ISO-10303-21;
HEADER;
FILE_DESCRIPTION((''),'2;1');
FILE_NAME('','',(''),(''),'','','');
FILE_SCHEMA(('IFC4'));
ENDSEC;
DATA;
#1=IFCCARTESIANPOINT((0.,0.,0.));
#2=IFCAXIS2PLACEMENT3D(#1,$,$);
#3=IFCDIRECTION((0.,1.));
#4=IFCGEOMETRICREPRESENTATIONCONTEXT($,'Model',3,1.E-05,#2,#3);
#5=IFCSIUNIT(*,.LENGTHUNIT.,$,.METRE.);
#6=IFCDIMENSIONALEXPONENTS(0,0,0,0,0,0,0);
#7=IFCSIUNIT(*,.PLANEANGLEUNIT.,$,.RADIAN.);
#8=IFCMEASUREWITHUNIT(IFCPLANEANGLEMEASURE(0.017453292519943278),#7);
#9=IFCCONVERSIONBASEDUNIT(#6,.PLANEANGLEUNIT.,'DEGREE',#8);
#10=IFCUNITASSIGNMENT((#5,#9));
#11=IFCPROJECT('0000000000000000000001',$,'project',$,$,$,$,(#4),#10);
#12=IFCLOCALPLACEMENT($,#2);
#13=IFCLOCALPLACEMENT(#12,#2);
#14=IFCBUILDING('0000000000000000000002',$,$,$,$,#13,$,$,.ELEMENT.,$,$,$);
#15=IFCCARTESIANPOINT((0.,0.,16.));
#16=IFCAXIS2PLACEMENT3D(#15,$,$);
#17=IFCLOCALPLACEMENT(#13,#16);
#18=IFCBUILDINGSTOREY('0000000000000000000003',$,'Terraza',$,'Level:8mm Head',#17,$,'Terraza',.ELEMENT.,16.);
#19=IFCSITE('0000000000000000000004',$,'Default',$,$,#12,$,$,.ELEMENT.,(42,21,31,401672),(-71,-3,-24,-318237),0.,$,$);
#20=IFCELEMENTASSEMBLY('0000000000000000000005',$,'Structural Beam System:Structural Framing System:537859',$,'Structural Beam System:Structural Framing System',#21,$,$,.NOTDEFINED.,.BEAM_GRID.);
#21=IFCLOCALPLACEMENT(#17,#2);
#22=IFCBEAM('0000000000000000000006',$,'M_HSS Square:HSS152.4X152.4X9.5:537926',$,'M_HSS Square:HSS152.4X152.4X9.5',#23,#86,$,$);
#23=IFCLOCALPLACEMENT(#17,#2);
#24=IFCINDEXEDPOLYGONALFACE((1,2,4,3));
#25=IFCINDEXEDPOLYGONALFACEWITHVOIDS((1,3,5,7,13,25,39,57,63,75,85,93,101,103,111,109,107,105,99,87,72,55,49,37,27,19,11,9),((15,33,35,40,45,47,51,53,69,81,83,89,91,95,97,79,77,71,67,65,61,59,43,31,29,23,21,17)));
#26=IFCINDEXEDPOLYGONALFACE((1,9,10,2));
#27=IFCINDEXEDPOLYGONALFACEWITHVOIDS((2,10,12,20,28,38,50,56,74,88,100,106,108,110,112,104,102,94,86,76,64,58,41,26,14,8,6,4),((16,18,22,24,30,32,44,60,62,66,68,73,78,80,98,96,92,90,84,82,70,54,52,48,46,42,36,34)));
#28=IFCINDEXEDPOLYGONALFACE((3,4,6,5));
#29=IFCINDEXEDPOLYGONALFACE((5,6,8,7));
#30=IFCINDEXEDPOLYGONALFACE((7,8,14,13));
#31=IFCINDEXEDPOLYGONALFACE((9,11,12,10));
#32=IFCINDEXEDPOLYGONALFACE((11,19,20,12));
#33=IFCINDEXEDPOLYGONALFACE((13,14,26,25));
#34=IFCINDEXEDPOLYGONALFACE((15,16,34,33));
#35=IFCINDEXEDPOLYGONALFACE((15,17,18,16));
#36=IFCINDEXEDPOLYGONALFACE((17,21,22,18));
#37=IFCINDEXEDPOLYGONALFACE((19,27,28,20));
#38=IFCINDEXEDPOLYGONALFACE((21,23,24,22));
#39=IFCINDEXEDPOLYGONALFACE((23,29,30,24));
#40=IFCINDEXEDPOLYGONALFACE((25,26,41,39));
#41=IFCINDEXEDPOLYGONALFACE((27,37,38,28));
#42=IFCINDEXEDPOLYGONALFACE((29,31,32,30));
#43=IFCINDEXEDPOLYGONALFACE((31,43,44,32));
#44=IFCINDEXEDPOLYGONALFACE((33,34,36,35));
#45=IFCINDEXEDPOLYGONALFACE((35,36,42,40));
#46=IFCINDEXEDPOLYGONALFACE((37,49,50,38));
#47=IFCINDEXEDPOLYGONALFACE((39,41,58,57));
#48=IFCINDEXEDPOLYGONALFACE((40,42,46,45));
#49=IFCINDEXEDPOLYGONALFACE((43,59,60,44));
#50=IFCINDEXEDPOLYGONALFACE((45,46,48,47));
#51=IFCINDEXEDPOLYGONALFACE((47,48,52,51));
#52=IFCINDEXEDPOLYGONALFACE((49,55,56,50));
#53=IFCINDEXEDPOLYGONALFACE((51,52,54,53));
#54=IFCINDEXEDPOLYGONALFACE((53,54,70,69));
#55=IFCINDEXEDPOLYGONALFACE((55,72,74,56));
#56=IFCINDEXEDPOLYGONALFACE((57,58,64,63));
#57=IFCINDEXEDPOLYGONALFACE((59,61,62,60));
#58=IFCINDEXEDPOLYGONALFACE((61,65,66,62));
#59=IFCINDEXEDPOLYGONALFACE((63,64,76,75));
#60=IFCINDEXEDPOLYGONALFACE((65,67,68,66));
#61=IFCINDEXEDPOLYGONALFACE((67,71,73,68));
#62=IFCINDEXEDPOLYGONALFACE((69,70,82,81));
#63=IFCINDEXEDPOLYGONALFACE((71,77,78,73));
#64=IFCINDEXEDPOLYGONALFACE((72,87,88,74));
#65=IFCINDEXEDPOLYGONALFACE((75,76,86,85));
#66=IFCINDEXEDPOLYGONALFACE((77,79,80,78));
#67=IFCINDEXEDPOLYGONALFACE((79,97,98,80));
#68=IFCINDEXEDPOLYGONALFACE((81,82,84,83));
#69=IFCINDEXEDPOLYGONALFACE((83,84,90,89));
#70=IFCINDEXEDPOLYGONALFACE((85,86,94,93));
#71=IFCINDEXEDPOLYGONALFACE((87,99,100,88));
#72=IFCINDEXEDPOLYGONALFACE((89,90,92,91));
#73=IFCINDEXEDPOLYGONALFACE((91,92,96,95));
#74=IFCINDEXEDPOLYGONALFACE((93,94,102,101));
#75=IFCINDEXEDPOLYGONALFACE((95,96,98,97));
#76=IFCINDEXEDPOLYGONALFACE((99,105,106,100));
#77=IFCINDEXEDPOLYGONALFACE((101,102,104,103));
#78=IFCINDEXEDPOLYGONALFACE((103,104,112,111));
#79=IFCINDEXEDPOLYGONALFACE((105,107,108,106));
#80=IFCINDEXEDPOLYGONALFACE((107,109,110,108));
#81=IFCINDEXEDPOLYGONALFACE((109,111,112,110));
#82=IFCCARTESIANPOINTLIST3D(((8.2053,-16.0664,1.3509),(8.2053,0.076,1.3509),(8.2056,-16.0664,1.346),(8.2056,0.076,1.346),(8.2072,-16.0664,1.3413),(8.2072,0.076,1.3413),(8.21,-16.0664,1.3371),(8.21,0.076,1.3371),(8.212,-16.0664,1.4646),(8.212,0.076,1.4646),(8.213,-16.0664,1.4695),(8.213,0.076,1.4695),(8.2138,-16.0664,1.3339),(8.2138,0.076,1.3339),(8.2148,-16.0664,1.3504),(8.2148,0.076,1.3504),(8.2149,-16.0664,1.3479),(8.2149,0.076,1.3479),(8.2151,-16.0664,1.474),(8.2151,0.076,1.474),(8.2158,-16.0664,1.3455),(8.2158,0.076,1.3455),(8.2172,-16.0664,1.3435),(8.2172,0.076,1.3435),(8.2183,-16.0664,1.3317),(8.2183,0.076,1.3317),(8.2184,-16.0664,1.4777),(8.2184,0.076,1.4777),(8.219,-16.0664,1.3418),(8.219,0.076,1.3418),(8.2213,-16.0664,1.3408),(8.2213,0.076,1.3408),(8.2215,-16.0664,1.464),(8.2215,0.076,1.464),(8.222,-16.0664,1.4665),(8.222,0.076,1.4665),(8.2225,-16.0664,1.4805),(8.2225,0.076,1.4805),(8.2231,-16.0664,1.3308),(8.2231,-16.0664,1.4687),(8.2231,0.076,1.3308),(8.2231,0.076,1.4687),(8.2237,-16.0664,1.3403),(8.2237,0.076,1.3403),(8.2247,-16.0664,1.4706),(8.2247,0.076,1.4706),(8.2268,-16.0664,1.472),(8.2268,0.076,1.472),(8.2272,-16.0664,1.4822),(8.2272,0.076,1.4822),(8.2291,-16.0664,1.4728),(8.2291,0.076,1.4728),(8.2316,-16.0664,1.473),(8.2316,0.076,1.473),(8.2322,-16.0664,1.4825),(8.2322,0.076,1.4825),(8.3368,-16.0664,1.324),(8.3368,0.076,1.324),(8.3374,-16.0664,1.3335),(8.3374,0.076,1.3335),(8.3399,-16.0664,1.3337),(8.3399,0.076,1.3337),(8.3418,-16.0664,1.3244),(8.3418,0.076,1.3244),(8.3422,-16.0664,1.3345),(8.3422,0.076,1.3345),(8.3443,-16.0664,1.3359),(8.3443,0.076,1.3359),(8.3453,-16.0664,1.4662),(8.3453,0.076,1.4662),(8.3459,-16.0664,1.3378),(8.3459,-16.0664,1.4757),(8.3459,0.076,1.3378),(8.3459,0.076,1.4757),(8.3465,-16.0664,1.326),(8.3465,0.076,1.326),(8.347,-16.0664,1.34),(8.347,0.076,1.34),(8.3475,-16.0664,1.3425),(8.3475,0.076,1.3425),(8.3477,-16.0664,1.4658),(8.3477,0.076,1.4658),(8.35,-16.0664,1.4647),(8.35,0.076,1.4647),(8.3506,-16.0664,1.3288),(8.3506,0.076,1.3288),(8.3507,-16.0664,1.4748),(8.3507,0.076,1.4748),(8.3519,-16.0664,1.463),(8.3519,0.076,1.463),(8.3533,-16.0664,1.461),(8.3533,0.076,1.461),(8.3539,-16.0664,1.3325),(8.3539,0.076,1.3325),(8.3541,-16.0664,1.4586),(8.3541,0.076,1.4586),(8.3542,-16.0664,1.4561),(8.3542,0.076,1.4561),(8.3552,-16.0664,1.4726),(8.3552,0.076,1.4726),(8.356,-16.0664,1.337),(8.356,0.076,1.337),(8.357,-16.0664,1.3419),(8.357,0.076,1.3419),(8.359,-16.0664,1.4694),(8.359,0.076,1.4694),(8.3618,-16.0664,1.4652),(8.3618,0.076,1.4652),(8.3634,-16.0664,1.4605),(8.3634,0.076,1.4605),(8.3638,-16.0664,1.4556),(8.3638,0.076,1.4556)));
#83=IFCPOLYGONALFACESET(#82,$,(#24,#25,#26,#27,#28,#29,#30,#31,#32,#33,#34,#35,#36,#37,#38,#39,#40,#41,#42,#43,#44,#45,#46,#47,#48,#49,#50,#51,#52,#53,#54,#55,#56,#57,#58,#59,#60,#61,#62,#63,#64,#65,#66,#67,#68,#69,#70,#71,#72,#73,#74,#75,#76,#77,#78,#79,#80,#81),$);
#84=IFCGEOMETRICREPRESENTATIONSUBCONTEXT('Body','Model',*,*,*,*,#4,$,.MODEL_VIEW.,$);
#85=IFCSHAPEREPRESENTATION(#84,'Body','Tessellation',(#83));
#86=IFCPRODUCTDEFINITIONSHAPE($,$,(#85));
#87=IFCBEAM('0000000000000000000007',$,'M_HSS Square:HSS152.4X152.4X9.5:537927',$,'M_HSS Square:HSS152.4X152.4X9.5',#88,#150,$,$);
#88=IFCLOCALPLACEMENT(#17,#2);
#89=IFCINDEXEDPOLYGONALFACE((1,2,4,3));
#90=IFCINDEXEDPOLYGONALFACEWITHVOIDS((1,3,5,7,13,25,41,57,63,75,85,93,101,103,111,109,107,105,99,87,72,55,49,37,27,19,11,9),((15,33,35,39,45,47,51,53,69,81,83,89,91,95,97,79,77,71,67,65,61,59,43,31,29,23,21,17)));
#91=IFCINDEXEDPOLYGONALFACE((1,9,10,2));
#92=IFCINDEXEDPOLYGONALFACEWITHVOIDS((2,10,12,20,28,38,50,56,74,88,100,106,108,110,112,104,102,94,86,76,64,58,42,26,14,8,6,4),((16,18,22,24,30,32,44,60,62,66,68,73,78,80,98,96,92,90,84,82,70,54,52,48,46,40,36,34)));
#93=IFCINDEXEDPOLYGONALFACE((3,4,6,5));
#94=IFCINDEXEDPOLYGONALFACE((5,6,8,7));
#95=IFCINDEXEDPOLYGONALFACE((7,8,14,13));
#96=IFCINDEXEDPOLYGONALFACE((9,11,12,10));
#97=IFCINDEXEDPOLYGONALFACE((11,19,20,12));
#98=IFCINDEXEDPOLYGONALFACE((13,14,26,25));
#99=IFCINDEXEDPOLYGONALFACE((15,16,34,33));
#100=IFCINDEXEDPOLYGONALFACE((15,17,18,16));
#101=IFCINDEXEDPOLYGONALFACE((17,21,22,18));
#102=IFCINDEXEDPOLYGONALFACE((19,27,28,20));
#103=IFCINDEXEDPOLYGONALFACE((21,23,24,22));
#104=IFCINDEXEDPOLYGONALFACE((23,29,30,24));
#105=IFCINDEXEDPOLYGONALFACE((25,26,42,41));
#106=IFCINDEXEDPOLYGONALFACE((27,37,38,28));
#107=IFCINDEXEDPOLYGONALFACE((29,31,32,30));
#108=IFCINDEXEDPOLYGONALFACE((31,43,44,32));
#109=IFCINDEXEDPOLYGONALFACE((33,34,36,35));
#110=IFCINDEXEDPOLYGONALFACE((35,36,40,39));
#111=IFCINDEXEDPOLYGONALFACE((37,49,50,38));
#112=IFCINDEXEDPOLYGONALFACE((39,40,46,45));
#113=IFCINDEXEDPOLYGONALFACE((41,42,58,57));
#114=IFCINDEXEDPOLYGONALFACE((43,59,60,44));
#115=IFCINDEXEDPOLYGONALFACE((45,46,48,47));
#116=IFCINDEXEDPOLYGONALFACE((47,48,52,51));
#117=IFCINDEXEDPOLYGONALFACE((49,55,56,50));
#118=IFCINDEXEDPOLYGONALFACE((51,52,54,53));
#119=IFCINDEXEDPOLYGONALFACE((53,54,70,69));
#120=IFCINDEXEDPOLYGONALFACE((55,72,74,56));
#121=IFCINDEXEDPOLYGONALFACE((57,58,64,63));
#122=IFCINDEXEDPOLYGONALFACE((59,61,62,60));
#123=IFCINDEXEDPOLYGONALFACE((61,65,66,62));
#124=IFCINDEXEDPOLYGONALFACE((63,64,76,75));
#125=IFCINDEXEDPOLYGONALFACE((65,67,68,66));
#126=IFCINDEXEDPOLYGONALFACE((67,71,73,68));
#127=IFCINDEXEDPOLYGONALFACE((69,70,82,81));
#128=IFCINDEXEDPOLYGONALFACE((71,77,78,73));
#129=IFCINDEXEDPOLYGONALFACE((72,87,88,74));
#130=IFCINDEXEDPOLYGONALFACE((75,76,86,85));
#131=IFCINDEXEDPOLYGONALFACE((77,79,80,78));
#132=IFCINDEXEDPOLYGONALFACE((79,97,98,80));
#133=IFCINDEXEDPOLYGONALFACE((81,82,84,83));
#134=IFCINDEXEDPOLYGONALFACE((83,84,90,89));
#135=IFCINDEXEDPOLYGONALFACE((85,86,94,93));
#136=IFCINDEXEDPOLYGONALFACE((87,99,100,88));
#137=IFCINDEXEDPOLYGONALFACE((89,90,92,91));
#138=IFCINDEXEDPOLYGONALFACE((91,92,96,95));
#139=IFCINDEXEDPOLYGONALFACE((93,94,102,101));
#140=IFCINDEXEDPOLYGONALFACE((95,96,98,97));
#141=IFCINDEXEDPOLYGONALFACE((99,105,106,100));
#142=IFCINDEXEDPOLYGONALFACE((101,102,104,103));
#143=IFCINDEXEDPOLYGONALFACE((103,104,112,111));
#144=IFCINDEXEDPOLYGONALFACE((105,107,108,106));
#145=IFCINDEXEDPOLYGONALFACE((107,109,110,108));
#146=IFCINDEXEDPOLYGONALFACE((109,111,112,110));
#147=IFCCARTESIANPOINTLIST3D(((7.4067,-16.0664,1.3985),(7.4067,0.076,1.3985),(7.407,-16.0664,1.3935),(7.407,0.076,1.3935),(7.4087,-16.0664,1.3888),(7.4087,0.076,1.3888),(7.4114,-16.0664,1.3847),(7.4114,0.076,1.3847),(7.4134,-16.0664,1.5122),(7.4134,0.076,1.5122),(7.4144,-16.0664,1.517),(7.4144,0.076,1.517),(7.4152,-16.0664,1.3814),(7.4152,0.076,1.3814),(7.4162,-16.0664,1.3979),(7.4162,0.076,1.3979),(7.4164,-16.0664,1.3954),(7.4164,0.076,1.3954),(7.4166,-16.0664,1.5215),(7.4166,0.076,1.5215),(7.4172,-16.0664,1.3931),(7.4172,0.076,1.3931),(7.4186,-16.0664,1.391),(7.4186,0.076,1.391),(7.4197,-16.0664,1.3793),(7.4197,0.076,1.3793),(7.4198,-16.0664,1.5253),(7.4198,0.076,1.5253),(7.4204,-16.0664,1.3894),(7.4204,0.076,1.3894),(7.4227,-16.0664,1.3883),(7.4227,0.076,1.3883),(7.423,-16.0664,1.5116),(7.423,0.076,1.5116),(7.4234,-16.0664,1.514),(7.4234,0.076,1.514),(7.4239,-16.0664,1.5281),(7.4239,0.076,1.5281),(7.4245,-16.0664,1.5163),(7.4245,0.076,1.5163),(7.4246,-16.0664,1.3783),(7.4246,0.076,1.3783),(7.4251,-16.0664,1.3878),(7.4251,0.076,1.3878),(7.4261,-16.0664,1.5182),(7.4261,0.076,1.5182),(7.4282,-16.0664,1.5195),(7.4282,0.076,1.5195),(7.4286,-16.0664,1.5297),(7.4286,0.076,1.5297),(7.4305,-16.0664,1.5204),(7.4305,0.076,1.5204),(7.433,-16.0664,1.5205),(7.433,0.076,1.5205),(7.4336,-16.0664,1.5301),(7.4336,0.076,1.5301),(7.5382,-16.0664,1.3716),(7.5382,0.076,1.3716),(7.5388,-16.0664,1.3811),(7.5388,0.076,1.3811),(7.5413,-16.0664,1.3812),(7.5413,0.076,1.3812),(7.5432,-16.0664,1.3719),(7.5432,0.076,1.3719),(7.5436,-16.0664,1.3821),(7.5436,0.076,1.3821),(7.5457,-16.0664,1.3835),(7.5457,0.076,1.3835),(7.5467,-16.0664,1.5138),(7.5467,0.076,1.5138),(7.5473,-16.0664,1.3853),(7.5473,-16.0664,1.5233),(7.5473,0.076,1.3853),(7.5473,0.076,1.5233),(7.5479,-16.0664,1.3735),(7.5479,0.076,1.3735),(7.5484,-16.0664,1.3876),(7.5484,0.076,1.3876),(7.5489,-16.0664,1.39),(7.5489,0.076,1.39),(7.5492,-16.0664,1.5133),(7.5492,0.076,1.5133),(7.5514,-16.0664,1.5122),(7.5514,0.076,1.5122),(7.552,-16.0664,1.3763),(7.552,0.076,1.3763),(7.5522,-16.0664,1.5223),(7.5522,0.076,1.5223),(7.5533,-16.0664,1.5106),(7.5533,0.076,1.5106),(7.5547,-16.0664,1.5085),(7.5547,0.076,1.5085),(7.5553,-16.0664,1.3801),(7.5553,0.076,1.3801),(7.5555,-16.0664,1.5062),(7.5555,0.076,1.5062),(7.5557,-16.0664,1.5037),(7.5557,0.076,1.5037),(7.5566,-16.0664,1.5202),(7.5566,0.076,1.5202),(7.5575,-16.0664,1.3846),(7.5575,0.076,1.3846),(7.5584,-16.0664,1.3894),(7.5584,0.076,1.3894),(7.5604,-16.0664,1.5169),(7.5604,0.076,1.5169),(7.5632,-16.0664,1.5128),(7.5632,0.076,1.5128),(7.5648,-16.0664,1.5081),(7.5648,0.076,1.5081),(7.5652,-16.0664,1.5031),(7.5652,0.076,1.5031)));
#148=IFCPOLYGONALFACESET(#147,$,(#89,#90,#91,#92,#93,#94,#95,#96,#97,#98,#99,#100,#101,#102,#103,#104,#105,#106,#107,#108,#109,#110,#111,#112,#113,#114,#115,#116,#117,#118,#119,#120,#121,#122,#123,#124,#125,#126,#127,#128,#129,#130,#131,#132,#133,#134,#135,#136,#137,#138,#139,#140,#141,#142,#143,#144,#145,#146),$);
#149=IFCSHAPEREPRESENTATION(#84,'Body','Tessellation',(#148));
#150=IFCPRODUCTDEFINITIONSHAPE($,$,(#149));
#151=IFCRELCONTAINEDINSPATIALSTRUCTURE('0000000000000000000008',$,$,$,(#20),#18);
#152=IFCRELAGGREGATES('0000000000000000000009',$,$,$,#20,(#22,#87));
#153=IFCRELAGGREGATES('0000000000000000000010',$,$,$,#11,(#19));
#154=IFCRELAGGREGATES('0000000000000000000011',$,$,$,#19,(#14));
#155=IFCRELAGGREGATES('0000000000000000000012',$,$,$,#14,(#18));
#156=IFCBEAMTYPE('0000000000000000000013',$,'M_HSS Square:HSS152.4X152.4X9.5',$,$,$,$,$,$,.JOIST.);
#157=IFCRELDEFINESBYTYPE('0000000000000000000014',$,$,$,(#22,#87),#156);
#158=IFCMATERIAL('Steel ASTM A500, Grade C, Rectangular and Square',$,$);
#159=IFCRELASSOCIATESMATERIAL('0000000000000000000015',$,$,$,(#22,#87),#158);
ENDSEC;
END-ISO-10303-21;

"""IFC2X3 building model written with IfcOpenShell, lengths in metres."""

from ifc_helpers import new_model, entity, si_unit, converted_unit, direction, frame, frame_2d, origin, place, context, subcontext, project, spatial, polyline, circle_curve, parameter, trimmed, segment, composite_curve, outline, extrude, material, type_object, element, aggregate, save


model = new_model("IFC2X3")

# Units and contexts
model_context = context("Model", 3, precision=1e-05, world=origin(), true_north=direction((0.0, 1.0)))
body_context = subcontext(model_context, "Body", "Model", "MODEL_VIEW")
ifc_project = project(units=[si_unit("LENGTHUNIT", "METRE"), converted_unit("PLANEANGLEUNIT", "DEGREE", entity("IfcPlaneAngleMeasure", 0.017453292519943278), si_unit("PLANEANGLEUNIT", "RADIAN"), dimensions=[0, 0, 0, 0, 0, 0, 0])], contexts=[model_context])

# Site, building, storey
site_placement = place(None, origin())
site = spatial("IfcSite", under=ifc_project, at=site_placement, Name="Default", CompositionType="ELEMENT", RefLatitude=(42, 21, 31, 401672), RefLongitude=(-71, -3, -24, -318237), RefElevation=0.0)
building_placement = place(site_placement, origin())
building = spatial("IfcBuilding", under=site, at=building_placement, CompositionType="ELEMENT")
storey_placement = place(building_placement, frame((0.0, 0.0, 16.0)))
storey = spatial("IfcBuildingStorey", under=building, at=storey_placement, Name="Terraza", ObjectType="Level:8mm Head", LongName="Terraza", CompositionType="ELEMENT", Elevation=16.0)

# Element assembly, beams
assembly_1_placement = place(storey_placement, origin())
assembly_1 = element("IfcElementAssembly", 1, at=assembly_1_placement, inside=storey, Name="Structural Beam System:Structural Framing System:537859", ObjectType="Structural Beam System:Structural Framing System", AssemblyPlace="NOTDEFINED", PredefinedType="BEAM_GRID")
ifc_material_1 = material(Name="Steel ASTM A500, Grade C, Rectangular and Square")
beam_type = type_object("IfcBeamType", Name="M_HSS Square:HSS152.4X152.4X9.5", PredefinedType="JOIST")
beam_1_placement = place(assembly_1_placement, frame((8.28, 0.076, 1.3274), z_axis=(0.0, 0.0, 1.0), x_axis=(0.0, -1.0, 0.0)))
beam_1 = element("IfcBeam", 2, at=beam_1_placement, type_object=beam_type, material=ifc_material_1, Name="M_HSS Square:HSS152.4X152.4X9.5:537926", ObjectType="M_HSS Square:HSS152.4X152.4X9.5", context=body_context, shape_type="SweptSolid", body=[
    extrude(outline(composite_curve([segment(polyline([(-0.0569, -0.076), (0.0569, -0.076)]), True, "CONTINUOUS"), segment(trimmed(circle_curve(frame_2d((0.0569, -0.0569), x_axis=(0.0, 1.0)), 0.0191), [parameter(180.0)], [parameter(270.0)], True, "PARAMETER"), True, "CONTINUOUS"), segment(polyline([(0.076, -0.0569), (0.076, 0.0569)]), True, "CONTINUOUS"), segment(trimmed(circle_curve(frame_2d((0.0569, 0.0569), x_axis=(0.0, 1.0)), 0.0191), [parameter(270.0)], [parameter(0.0)], True, "PARAMETER"), True, "CONTINUOUS"), segment(polyline([(0.0569, 0.076), (-0.0569, 0.076)]), True, "CONTINUOUS"), segment(trimmed(circle_curve(frame_2d((-0.0569, 0.0569), x_axis=(0.0, 1.0)), 0.0191), [parameter(0.0)], [parameter(90.0)], True, "PARAMETER"), True, "CONTINUOUS"), segment(polyline([(-0.076, 0.0569), (-0.076, -0.0569)]), True, "CONTINUOUS"), segment(trimmed(circle_curve(frame_2d((-0.0569, -0.0569), x_axis=(0.0, 1.0)), 0.0191), [parameter(90.0)], [parameter(180.0)], True, "PARAMETER"), True, "CONTINUOUS")], self_intersect=False), holes=[composite_curve([segment(trimmed(circle_curve(frame_2d((-0.0569, 0.0569), x_axis=(0.0, 1.0)), 0.0095), [parameter(360.0)], [parameter(90.0)], True, "PARAMETER"), False, "CONTINUOUS"), segment(polyline([(-0.0569, 0.0665), (0.0569, 0.0665)]), True, "CONTINUOUS"), segment(trimmed(circle_curve(frame_2d((0.0569, 0.0569), x_axis=(0.0, 1.0)), 0.0095), [parameter(270.0)], [parameter(360.0)], True, "PARAMETER"), False, "CONTINUOUS"), segment(polyline([(0.0665, 0.0569), (0.0665, -0.0569)]), True, "CONTINUOUS"), segment(trimmed(circle_curve(frame_2d((0.0569, -0.0569), x_axis=(0.0, 1.0)), 0.0095), [parameter(180.0)], [parameter(270.0)], True, "PARAMETER"), False, "CONTINUOUS"), segment(polyline([(0.0569, -0.0665), (-0.0569, -0.0665)]), True, "CONTINUOUS"), segment(trimmed(circle_curve(frame_2d((-0.0569, -0.0569), x_axis=(0.0, 1.0)), 0.0095), [parameter(90.0)], [parameter(180.0)], True, "PARAMETER"), False, "CONTINUOUS"), segment(polyline([(-0.0665, -0.0569), (-0.0665, 0.0569)]), True, "CONTINUOUS")], self_intersect=False)]), frame((0.0, 0.0045, 0.0759), z_axis=(1.0, 0.0, 0.0), x_axis=(0.0, -0.059434, -0.998232)), (0.0, 0.0, 1.0), 16.1424),
])
beam_2_placement = place(assembly_1_placement, frame((7.4814, 0.076, 1.3749), z_axis=(0.0, 0.0, 1.0), x_axis=(0.0, -1.0, 0.0)))
beam_2 = element("IfcBeam", 3, at=beam_2_placement, type_object=beam_type, material=ifc_material_1, Name="M_HSS Square:HSS152.4X152.4X9.5:537927", ObjectType="M_HSS Square:HSS152.4X152.4X9.5", context=body_context, shape_type="SweptSolid", body=[
    extrude(outline(composite_curve([segment(polyline([(-0.0569, -0.076), (0.0569, -0.076)]), True, "CONTINUOUS"), segment(trimmed(circle_curve(frame_2d((0.0569, -0.0569), x_axis=(0.0, 1.0)), 0.0191), [parameter(180.0)], [parameter(270.0)], True, "PARAMETER"), True, "CONTINUOUS"), segment(polyline([(0.076, -0.0569), (0.076, 0.0569)]), True, "CONTINUOUS"), segment(trimmed(circle_curve(frame_2d((0.0569, 0.0569), x_axis=(0.0, 1.0)), 0.0191), [parameter(270.0)], [parameter(0.0)], True, "PARAMETER"), True, "CONTINUOUS"), segment(polyline([(0.0569, 0.076), (-0.0569, 0.076)]), True, "CONTINUOUS"), segment(trimmed(circle_curve(frame_2d((-0.0569, 0.0569), x_axis=(0.0, 1.0)), 0.0191), [parameter(0.0)], [parameter(90.0)], True, "PARAMETER"), True, "CONTINUOUS"), segment(polyline([(-0.076, 0.0569), (-0.076, -0.0569)]), True, "CONTINUOUS"), segment(trimmed(circle_curve(frame_2d((-0.0569, -0.0569), x_axis=(0.0, 1.0)), 0.0191), [parameter(90.0)], [parameter(180.0)], True, "PARAMETER"), True, "CONTINUOUS")], self_intersect=False), holes=[composite_curve([segment(trimmed(circle_curve(frame_2d((-0.0569, 0.0569), x_axis=(0.0, 1.0)), 0.0095), [parameter(360.0)], [parameter(90.0)], True, "PARAMETER"), False, "CONTINUOUS"), segment(polyline([(-0.0569, 0.0665), (0.0569, 0.0665)]), True, "CONTINUOUS"), segment(trimmed(circle_curve(frame_2d((0.0569, 0.0569), x_axis=(0.0, 1.0)), 0.0095), [parameter(270.0)], [parameter(360.0)], True, "PARAMETER"), False, "CONTINUOUS"), segment(polyline([(0.0665, 0.0569), (0.0665, -0.0569)]), True, "CONTINUOUS"), segment(trimmed(circle_curve(frame_2d((0.0569, -0.0569), x_axis=(0.0, 1.0)), 0.0095), [parameter(180.0)], [parameter(270.0)], True, "PARAMETER"), False, "CONTINUOUS"), segment(polyline([(0.0569, -0.0665), (-0.0569, -0.0665)]), True, "CONTINUOUS"), segment(trimmed(circle_curve(frame_2d((-0.0569, -0.0569), x_axis=(0.0, 1.0)), 0.0095), [parameter(90.0)], [parameter(180.0)], True, "PARAMETER"), False, "CONTINUOUS"), segment(polyline([(-0.0665, -0.0569), (-0.0665, 0.0569)]), True, "CONTINUOUS")], self_intersect=False)]), frame((0.0, 0.0045, 0.0759), z_axis=(1.0, 0.0, 0.0), x_axis=(0.0, -0.059434, -0.998232)), (0.0, 0.0, 1.0), 16.1424),
])
aggregate(assembly_1, [beam_1, beam_2])

save(model, "model.ifc")
